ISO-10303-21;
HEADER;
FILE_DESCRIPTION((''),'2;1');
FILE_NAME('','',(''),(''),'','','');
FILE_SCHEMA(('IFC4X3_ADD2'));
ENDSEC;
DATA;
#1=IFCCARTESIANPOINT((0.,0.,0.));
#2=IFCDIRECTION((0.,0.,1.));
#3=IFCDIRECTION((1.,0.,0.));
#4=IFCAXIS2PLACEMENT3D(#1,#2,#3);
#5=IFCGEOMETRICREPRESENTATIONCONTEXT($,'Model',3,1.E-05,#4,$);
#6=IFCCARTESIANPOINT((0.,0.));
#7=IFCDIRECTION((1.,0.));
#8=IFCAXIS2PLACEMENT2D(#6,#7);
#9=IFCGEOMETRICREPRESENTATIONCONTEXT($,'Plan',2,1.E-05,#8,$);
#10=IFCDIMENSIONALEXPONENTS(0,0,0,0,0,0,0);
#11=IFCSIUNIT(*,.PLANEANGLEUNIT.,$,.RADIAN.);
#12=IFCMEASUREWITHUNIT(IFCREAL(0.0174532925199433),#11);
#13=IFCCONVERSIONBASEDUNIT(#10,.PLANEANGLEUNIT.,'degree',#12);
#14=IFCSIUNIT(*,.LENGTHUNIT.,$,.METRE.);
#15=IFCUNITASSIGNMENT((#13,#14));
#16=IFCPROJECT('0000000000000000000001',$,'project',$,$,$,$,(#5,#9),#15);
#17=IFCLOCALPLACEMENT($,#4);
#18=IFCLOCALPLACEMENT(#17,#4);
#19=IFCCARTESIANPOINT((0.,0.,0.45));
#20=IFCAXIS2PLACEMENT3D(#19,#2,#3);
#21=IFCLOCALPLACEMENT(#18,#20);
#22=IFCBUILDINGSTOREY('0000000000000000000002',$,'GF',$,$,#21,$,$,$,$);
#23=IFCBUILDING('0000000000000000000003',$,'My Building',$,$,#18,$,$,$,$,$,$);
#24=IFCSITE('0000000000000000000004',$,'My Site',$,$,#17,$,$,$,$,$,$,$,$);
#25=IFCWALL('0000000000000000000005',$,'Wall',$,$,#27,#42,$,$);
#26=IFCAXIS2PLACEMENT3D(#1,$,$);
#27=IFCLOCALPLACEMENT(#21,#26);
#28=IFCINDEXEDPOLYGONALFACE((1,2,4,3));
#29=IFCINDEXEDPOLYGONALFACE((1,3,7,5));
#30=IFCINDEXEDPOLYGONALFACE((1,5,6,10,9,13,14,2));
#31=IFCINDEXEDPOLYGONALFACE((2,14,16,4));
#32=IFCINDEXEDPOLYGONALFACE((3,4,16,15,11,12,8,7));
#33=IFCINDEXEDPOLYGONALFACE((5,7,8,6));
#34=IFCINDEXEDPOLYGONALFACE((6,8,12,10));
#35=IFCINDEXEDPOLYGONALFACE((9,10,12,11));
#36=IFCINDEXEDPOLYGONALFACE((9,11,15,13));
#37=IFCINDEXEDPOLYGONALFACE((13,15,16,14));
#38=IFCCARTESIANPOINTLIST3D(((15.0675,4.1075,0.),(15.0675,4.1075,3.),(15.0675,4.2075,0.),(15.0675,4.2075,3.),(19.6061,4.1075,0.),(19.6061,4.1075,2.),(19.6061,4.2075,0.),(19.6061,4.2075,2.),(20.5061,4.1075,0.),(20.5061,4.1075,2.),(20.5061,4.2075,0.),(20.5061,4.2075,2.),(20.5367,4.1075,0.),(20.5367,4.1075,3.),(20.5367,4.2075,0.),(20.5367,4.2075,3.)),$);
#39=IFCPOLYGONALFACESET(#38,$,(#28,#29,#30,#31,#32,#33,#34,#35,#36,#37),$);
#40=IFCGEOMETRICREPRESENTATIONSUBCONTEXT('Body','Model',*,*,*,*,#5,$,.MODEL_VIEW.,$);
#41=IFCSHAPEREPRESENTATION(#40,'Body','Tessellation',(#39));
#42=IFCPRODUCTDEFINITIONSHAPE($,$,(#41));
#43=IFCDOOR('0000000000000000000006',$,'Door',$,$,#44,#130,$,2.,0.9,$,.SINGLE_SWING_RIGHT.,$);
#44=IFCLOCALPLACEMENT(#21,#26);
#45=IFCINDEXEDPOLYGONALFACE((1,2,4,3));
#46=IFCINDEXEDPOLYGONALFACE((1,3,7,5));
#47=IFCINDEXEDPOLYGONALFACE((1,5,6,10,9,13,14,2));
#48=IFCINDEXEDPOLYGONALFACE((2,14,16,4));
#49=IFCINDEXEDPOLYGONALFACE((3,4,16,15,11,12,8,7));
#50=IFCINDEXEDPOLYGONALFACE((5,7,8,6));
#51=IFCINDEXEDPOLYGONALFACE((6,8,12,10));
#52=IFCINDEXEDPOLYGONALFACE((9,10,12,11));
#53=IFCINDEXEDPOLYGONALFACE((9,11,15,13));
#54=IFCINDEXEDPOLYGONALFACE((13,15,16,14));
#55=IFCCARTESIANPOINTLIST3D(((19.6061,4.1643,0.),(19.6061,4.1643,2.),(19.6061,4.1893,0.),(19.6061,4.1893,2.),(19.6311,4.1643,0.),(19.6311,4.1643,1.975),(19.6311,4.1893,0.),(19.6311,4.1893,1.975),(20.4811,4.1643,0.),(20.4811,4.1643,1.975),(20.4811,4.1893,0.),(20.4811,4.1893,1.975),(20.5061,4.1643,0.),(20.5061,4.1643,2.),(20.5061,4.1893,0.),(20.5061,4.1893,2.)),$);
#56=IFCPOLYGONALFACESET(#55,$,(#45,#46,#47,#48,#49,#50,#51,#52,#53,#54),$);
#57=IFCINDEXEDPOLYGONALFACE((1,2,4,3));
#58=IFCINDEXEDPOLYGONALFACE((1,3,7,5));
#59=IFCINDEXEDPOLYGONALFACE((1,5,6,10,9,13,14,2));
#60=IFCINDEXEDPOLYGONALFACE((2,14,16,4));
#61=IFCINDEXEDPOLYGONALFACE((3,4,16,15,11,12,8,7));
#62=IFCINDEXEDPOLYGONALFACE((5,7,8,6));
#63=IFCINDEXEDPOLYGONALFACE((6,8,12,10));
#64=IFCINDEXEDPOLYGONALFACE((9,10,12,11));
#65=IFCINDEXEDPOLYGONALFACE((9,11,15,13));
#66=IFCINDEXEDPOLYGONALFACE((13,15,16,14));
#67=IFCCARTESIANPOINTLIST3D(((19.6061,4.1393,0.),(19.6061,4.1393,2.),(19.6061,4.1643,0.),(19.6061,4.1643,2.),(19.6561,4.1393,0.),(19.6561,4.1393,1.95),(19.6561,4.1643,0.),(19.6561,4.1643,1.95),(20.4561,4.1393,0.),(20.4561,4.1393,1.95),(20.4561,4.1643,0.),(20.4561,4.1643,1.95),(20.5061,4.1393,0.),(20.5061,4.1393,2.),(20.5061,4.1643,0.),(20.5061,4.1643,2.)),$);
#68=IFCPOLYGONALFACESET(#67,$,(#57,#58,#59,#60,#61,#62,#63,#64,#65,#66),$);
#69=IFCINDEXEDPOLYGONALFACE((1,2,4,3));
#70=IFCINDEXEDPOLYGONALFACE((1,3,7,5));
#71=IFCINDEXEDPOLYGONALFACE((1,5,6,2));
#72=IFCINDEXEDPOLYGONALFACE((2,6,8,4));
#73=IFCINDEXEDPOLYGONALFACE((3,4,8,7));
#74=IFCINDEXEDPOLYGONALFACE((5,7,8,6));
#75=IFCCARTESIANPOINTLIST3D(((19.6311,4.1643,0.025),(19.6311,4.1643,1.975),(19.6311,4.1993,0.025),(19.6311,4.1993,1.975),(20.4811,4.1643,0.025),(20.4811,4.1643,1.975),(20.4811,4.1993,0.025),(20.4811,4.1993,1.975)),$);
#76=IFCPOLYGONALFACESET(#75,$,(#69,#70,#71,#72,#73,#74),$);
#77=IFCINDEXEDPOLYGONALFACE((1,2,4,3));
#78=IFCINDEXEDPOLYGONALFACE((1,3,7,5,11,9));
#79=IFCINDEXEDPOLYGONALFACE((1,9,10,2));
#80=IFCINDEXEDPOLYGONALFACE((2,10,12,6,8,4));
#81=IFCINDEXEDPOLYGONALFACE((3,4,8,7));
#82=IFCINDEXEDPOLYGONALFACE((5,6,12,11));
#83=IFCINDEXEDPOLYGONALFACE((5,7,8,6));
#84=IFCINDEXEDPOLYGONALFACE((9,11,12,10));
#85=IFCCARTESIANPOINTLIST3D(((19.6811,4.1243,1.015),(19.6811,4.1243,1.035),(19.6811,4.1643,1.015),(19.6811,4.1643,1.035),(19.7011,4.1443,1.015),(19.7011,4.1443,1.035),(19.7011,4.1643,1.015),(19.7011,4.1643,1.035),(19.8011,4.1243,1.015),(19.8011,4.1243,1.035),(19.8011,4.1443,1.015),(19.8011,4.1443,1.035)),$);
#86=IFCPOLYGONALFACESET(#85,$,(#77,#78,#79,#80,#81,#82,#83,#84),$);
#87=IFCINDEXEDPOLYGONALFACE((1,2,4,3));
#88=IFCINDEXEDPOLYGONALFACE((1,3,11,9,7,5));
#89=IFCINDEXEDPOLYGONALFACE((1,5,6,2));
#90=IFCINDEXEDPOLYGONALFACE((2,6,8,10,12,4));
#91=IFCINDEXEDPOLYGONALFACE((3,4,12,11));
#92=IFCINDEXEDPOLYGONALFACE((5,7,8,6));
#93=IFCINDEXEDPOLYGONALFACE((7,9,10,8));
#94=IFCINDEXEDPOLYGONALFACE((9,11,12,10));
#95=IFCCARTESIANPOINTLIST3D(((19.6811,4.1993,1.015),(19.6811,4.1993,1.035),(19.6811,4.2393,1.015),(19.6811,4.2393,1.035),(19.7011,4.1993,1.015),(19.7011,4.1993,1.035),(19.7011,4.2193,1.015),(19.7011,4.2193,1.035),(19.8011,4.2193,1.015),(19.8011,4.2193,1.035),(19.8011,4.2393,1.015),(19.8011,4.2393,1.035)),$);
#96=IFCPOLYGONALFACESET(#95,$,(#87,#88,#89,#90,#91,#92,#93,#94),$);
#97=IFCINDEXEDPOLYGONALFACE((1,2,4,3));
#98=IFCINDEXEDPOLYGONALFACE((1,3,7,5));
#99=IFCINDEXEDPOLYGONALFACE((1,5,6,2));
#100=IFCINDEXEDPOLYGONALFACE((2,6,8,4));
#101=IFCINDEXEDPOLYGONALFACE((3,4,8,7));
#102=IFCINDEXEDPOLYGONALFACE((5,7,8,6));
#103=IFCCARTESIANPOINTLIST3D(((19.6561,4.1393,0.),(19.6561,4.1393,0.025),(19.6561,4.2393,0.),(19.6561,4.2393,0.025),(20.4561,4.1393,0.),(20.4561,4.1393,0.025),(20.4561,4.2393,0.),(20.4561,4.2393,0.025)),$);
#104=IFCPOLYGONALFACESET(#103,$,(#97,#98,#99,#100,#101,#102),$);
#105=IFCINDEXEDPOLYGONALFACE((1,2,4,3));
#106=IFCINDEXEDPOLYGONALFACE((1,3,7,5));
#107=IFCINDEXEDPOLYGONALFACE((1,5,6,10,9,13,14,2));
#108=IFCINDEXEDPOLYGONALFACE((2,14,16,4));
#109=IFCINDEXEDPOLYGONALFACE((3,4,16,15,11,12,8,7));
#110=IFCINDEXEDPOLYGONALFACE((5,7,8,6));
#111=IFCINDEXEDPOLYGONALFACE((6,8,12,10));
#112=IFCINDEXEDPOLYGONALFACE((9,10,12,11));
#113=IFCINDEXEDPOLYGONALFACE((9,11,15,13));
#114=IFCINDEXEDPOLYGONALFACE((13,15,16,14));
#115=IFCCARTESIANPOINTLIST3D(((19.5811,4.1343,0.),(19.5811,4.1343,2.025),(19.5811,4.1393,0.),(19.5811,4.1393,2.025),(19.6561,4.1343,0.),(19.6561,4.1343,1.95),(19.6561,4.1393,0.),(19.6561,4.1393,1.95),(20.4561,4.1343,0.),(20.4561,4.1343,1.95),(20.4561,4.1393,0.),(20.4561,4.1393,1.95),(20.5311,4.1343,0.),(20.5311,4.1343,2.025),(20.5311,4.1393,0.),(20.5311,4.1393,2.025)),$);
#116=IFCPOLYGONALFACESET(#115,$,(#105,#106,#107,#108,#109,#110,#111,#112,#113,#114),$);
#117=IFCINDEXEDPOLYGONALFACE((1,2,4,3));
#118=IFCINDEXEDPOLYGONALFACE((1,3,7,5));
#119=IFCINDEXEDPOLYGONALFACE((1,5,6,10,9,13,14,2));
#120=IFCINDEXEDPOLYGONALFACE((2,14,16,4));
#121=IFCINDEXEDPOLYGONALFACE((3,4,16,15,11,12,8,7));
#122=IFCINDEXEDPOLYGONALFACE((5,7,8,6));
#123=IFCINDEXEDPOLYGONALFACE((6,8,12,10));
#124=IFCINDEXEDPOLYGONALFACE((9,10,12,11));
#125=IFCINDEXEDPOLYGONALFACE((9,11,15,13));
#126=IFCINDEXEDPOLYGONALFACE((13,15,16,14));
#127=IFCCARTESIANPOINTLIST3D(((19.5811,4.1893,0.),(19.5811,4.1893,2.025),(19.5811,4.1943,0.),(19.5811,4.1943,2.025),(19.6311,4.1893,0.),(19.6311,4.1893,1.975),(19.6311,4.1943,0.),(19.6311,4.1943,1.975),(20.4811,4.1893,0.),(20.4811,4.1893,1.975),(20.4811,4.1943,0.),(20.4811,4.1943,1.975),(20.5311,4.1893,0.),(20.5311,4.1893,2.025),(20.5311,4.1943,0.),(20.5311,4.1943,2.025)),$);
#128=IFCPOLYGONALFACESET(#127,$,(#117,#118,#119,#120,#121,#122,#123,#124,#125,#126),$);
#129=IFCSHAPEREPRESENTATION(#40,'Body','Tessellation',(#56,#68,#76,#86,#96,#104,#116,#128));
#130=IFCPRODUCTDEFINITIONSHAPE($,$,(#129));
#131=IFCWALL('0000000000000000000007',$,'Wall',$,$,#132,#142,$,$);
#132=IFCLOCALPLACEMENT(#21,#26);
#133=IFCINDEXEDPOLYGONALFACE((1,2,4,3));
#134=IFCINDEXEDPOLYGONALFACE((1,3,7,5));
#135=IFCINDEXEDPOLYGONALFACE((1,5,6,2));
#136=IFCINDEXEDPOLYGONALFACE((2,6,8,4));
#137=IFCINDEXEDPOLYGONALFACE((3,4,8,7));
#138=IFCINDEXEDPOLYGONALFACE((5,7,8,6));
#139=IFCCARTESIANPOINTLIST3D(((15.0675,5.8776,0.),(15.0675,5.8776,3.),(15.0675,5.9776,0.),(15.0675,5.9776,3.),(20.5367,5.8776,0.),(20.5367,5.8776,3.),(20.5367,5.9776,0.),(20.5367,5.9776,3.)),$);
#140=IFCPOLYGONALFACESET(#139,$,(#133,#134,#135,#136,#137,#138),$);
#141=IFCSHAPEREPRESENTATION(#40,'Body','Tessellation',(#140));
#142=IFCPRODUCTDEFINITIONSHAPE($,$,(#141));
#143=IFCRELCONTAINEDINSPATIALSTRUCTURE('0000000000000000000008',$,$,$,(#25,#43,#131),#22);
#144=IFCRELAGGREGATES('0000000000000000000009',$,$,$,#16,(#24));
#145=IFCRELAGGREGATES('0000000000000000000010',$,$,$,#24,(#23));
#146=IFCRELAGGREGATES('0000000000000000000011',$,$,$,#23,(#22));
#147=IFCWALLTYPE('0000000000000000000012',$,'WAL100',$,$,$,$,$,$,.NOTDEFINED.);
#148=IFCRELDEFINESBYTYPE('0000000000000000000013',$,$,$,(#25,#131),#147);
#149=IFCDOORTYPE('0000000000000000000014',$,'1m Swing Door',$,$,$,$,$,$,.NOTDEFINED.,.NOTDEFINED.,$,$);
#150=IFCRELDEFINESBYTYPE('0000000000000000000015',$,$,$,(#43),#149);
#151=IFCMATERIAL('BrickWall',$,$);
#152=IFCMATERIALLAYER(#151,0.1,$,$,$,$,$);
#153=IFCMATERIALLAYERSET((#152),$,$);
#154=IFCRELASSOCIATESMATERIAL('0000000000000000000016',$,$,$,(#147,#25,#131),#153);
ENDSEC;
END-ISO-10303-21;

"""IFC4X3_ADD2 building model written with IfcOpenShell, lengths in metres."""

from ifc_helpers import new_model, entity, si_unit, converted_unit, frame, origin_with_axes, origin_2d_with_axis, place, context, subcontext, project, spatial, line, indexed_curve, outline, extrude, shape, source, transform, mapped, material, layer, layer_set, layer_usage, type_object, type_shapes, element, fill, save


model = new_model("IFC4X3_ADD2")

# Units and contexts
model_context = context("Model", 3, precision=1e-05, world=origin_with_axes())
plan_context = context("Plan", 2, precision=1e-05, world=origin_2d_with_axis())
body_context_1 = subcontext(model_context, "Body", "Model", "MODEL_VIEW")
body_context_2 = subcontext(plan_context, "Body", "Plan", "PLAN_VIEW")
ifc_project = project(units=[converted_unit("PLANEANGLEUNIT", "degree", entity("IfcReal", 0.0174532925199433), si_unit("PLANEANGLEUNIT", "RADIAN"), dimensions=[0, 0, 0, 0, 0, 0, 0]), si_unit("LENGTHUNIT", "METRE")], contexts=[model_context, plan_context])

# Site, building, storey
site_placement = place(None, origin_with_axes())
site = spatial("IfcSite", under=ifc_project, at=site_placement, Name="My Site")
building_placement = place(site_placement, origin_with_axes())
building = spatial("IfcBuilding", under=site, at=building_placement, Name="My Building")
storey_placement = place(building_placement, frame((0.0, 0.0, 0.45), z_axis=(0.0, 0.0, 1.0), x_axis=(1.0, 0.0, 0.0)))
storey = spatial("IfcBuildingStorey", under=building, at=storey_placement, Name="GF")

# Shared definitions
ifc_material_1 = material(Name="BrickWall")

# Wall, opening, door
ifc_layer_1 = layer(ifc_material_1, 0.1)
ifc_layer_set_1 = layer_set([ifc_layer_1])
ifc_layer_usage_1 = layer_usage(ifc_layer_set_1, "AXIS2", "POSITIVE", 0.0)
wall_type_1 = type_object("IfcWallType", Name="WAL100", PredefinedType="NOTDEFINED", material=ifc_layer_set_1)
wall_1_placement = place(storey_placement, frame((15.0675, 4.1075, 0.0), z_axis=(0.0, 0.0, 1.0), x_axis=(1.0, 0.0, 0.0)))
wall_1 = element("IfcWall", 1, at=wall_1_placement, inside=storey, type_object=wall_type_1, material=ifc_layer_usage_1, Name="Wall", context=body_context_1, shape_type="SweptSolid", body=[
    extrude(outline(indexed_curve([(0.0, 0.0), (0.0, 0.1), (5.4693, 0.1), (5.4693, 0.0), (0.0, 0.0)], self_intersect=False)), origin_with_axes(), (0.0, 0.0, 1.0), 3.0),
])
shared_shape_1 = source(origin_with_axes(), body_context_1, "Body", "SweptSolid", [
    extrude(outline(indexed_curve([(0.0, 0.0), (0.9, 0.0), (0.9, 2.0), (0.0, 2.0)], segments=[line(1, 2, 3, 4, 1)])), frame((0.0, -0.6, 0.0), z_axis=(0.0, -1.0, 0.0), x_axis=(1.0, 0.0, 0.0)), (0.0, 0.0, -1.0), 1.2),
])
opening_1_placement = place(wall_1_placement, frame((4.5386, 0.0318, 0.0), z_axis=(0.0, 0.0, 1.0), x_axis=(1.0, 0.0, 0.0)))
opening_1 = element("IfcOpeningElement", 2, at=opening_1_placement, cuts=wall_1, PredefinedType="OPENING", context=body_context_1, shape_type="MappedRepresentation", body=[
    mapped(shared_shape_1, transform((0.0, 0.0, 0.0), x_axis=(1.0, 0.0, 0.0), y_axis=(0.0, 1.0, 0.0), z_axis=(0.0, 0.0, 1.0), scale=1.0)),
])
door_type_1 = type_object("IfcDoorType", Name="1m Swing Door", OperationType="NOTDEFINED", PredefinedType="NOTDEFINED")
shared_shape_2 = source(origin_with_axes(), body_context_1, "Body", "SweptSolid", [
    extrude(outline(indexed_curve([(0.0, 0.0), (0.0, 2.0), (0.9, 2.0), (0.9, 0.0), (0.875, 0.0), (0.875, 1.975), (0.025, 1.975), (0.025, 0.0)], segments=[line(1, 2, 3, 4, 5, 6, 7, 8, 1)])), frame((0.0, 0.025, 0.0), z_axis=(0.0, -1.0, 0.0), x_axis=(1.0, 0.0, 0.0)), (0.0, 0.0, -1.0), 0.025),
    extrude(outline(indexed_curve([(0.0, 0.0), (0.0, 2.0), (0.9, 2.0), (0.9, 0.0), (0.85, 0.0), (0.85, 1.95), (0.05, 1.95), (0.05, 0.0)], segments=[line(1, 2, 3, 4, 5, 6, 7, 8, 1)])), frame((0.0, 0.0, 0.0), z_axis=(0.0, -1.0, 0.0), x_axis=(1.0, 0.0, 0.0)), (0.0, 0.0, -1.0), 0.025),
    extrude(outline(indexed_curve([(0.0, 0.0), (0.85, 0.0), (0.85, 0.035), (0.0, 0.035)], segments=[line(1, 2, 3, 4, 1)])), frame((0.025, 0.025, 0.025), z_axis=(0.0, 0.0, 1.0), x_axis=(1.0, 0.0, 0.0)), (0.0, 0.0, 1.0), 1.95),
    extrude(outline(indexed_curve([(0.0, 0.0), (0.0, -0.04), (0.12, -0.04), (0.12, -0.02), (0.02, -0.02), (0.02, 0.0)], segments=[line(1, 2, 3, 4, 5, 6, 1)])), frame((0.075, 0.025, 1.015), z_axis=(0.0, 0.0, 1.0), x_axis=(1.0, 0.0, 0.0)), (0.0, 0.0, 1.0), 0.02),
    extrude(outline(indexed_curve([(0.0, 0.0), (0.0, 0.04), (0.12, 0.04), (0.12, 0.02), (0.02, 0.02), (0.02, 0.0)], segments=[line(1, 2, 3, 4, 5, 6, 1)])), frame((0.075, 0.06, 1.015), z_axis=(0.0, 0.0, 1.0), x_axis=(1.0, 0.0, 0.0)), (0.0, 0.0, 1.0), 0.02),
    extrude(outline(indexed_curve([(0.0, 0.0), (0.8, 0.0), (0.8, 0.1), (0.0, 0.1)], segments=[line(1, 2, 3, 4, 1)])), frame((0.05, 0.0, 0.0), z_axis=(0.0, 0.0, 1.0), x_axis=(1.0, 0.0, 0.0)), (0.0, 0.0, 1.0), 0.025),
    extrude(outline(indexed_curve([(0.0, 0.0), (0.0, 2.025), (0.95, 2.025), (0.95, 0.0), (0.875, 0.0), (0.875, 1.95), (0.075, 1.95), (0.075, 0.0)], segments=[line(1, 2, 3, 4, 5, 6, 7, 8, 1)])), frame((-0.025, -0.005, 0.0), z_axis=(0.0, -1.0, 0.0), x_axis=(1.0, 0.0, 0.0)), (0.0, 0.0, -1.0), 0.005),
    extrude(outline(indexed_curve([(0.0, 0.0), (0.0, 2.025), (0.95, 2.025), (0.95, 0.0), (0.9, 0.0), (0.9, 1.975), (0.05, 1.975), (0.05, 0.0)], segments=[line(1, 2, 3, 4, 5, 6, 7, 8, 1)])), frame((-0.025, 0.05, 0.0), z_axis=(0.0, -1.0, 0.0), x_axis=(1.0, 0.0, 0.0)), (0.0, 0.0, -1.0), 0.005),
])
shared_shape_3 = source(origin_with_axes(), body_context_2, "Body", "Curve2D", [
    entity("IfcIndexedPolyCurve", entity("IfcCartesianPointList2D", [[0.0, 0.0], [0.0, 0.05], [0.025, 0.05], [0.025, 0.025], [0.05, 0.025], [0.05, 0.0]]), [entity("IfcLineIndex", [1, 2, 3, 4, 5, 6, 1])]),
    entity("IfcIndexedPolyCurve", entity("IfcCartesianPointList2D", [[0.9, 0.0], [0.9, 0.05], [0.875, 0.05], [0.875, 0.025], [0.85, 0.025], [0.85, 0.0]]), [entity("IfcLineIndex", [1, 2, 3, 4, 5, 6, 1])]),
    entity("IfcTrimmedCurve", entity("IfcEllipse", entity("IfcAxis2Placement2D", entity("IfcCartesianPoint", [0.84, 0.05]), entity("IfcDirection", [1.0, 0.0])), 0.815, 0.85), [entity("IfcCartesianPoint", [0.84, 0.9])], [entity("IfcCartesianPoint", [0.025, 0.05])], True, "CARTESIAN"),
    entity("IfcIndexedPolyCurve", entity("IfcCartesianPointList2D", [[0.875, 0.05], [0.84, 0.05], [0.84, 0.9], [0.875, 0.9]]), [entity("IfcLineIndex", [1, 2, 3, 4, 1])]),
])
type_shapes(door_type_1, [shared_shape_2, shared_shape_3])
door_1_placement = place(opening_1_placement, frame((0.0, 0.0, 0.0), z_axis=(0.0, 0.0, 1.0), x_axis=(1.0, 0.0, 0.0)))
door_1 = element("IfcDoor", 3, at=door_1_placement, inside=storey, type_object=door_type_1, Name="Door", OperationType="SINGLE_SWING_RIGHT", OverallHeight=2.0, OverallWidth=0.9, shapes=[
    shape(body_context_1, "Body", "MappedRepresentation", [mapped(shared_shape_2, transform((0.0, 0.0, 0.0), x_axis=(1.0, 0.0, 0.0), y_axis=(0.0, 1.0, 0.0), z_axis=(0.0, 0.0, 1.0), scale=1.0))]),
    shape(body_context_2, "Body", "MappedRepresentation", [mapped(shared_shape_3, transform((0.0, 0.0, 0.0), x_axis=(1.0, 0.0, 0.0), y_axis=(0.0, 1.0, 0.0), z_axis=(0.0, 0.0, 1.0), scale=1.0))]),
])
fill(opening_1, door_1)

# Wall
ifc_layer_usage_2 = layer_usage(ifc_layer_set_1, "AXIS2", "POSITIVE", 0.0)
wall_2_placement = place(storey_placement, frame((15.0675, 5.8776, 0.0), z_axis=(0.0, 0.0, 1.0), x_axis=(1.0, 0.0, 0.0)))
element("IfcWall", 4, at=wall_2_placement, inside=storey, type_object=wall_type_1, material=ifc_layer_usage_2, Name="Wall", context=body_context_1, shape_type="SweptSolid", body=[
    extrude(outline(indexed_curve([(0.0, 0.0), (0.0, 0.1), (5.4693, 0.1), (5.4693, 0.0), (0.0, 0.0)], self_intersect=False)), origin_with_axes(), (0.0, 0.0, 1.0), 3.0),
])

save(model, "model.ifc")
